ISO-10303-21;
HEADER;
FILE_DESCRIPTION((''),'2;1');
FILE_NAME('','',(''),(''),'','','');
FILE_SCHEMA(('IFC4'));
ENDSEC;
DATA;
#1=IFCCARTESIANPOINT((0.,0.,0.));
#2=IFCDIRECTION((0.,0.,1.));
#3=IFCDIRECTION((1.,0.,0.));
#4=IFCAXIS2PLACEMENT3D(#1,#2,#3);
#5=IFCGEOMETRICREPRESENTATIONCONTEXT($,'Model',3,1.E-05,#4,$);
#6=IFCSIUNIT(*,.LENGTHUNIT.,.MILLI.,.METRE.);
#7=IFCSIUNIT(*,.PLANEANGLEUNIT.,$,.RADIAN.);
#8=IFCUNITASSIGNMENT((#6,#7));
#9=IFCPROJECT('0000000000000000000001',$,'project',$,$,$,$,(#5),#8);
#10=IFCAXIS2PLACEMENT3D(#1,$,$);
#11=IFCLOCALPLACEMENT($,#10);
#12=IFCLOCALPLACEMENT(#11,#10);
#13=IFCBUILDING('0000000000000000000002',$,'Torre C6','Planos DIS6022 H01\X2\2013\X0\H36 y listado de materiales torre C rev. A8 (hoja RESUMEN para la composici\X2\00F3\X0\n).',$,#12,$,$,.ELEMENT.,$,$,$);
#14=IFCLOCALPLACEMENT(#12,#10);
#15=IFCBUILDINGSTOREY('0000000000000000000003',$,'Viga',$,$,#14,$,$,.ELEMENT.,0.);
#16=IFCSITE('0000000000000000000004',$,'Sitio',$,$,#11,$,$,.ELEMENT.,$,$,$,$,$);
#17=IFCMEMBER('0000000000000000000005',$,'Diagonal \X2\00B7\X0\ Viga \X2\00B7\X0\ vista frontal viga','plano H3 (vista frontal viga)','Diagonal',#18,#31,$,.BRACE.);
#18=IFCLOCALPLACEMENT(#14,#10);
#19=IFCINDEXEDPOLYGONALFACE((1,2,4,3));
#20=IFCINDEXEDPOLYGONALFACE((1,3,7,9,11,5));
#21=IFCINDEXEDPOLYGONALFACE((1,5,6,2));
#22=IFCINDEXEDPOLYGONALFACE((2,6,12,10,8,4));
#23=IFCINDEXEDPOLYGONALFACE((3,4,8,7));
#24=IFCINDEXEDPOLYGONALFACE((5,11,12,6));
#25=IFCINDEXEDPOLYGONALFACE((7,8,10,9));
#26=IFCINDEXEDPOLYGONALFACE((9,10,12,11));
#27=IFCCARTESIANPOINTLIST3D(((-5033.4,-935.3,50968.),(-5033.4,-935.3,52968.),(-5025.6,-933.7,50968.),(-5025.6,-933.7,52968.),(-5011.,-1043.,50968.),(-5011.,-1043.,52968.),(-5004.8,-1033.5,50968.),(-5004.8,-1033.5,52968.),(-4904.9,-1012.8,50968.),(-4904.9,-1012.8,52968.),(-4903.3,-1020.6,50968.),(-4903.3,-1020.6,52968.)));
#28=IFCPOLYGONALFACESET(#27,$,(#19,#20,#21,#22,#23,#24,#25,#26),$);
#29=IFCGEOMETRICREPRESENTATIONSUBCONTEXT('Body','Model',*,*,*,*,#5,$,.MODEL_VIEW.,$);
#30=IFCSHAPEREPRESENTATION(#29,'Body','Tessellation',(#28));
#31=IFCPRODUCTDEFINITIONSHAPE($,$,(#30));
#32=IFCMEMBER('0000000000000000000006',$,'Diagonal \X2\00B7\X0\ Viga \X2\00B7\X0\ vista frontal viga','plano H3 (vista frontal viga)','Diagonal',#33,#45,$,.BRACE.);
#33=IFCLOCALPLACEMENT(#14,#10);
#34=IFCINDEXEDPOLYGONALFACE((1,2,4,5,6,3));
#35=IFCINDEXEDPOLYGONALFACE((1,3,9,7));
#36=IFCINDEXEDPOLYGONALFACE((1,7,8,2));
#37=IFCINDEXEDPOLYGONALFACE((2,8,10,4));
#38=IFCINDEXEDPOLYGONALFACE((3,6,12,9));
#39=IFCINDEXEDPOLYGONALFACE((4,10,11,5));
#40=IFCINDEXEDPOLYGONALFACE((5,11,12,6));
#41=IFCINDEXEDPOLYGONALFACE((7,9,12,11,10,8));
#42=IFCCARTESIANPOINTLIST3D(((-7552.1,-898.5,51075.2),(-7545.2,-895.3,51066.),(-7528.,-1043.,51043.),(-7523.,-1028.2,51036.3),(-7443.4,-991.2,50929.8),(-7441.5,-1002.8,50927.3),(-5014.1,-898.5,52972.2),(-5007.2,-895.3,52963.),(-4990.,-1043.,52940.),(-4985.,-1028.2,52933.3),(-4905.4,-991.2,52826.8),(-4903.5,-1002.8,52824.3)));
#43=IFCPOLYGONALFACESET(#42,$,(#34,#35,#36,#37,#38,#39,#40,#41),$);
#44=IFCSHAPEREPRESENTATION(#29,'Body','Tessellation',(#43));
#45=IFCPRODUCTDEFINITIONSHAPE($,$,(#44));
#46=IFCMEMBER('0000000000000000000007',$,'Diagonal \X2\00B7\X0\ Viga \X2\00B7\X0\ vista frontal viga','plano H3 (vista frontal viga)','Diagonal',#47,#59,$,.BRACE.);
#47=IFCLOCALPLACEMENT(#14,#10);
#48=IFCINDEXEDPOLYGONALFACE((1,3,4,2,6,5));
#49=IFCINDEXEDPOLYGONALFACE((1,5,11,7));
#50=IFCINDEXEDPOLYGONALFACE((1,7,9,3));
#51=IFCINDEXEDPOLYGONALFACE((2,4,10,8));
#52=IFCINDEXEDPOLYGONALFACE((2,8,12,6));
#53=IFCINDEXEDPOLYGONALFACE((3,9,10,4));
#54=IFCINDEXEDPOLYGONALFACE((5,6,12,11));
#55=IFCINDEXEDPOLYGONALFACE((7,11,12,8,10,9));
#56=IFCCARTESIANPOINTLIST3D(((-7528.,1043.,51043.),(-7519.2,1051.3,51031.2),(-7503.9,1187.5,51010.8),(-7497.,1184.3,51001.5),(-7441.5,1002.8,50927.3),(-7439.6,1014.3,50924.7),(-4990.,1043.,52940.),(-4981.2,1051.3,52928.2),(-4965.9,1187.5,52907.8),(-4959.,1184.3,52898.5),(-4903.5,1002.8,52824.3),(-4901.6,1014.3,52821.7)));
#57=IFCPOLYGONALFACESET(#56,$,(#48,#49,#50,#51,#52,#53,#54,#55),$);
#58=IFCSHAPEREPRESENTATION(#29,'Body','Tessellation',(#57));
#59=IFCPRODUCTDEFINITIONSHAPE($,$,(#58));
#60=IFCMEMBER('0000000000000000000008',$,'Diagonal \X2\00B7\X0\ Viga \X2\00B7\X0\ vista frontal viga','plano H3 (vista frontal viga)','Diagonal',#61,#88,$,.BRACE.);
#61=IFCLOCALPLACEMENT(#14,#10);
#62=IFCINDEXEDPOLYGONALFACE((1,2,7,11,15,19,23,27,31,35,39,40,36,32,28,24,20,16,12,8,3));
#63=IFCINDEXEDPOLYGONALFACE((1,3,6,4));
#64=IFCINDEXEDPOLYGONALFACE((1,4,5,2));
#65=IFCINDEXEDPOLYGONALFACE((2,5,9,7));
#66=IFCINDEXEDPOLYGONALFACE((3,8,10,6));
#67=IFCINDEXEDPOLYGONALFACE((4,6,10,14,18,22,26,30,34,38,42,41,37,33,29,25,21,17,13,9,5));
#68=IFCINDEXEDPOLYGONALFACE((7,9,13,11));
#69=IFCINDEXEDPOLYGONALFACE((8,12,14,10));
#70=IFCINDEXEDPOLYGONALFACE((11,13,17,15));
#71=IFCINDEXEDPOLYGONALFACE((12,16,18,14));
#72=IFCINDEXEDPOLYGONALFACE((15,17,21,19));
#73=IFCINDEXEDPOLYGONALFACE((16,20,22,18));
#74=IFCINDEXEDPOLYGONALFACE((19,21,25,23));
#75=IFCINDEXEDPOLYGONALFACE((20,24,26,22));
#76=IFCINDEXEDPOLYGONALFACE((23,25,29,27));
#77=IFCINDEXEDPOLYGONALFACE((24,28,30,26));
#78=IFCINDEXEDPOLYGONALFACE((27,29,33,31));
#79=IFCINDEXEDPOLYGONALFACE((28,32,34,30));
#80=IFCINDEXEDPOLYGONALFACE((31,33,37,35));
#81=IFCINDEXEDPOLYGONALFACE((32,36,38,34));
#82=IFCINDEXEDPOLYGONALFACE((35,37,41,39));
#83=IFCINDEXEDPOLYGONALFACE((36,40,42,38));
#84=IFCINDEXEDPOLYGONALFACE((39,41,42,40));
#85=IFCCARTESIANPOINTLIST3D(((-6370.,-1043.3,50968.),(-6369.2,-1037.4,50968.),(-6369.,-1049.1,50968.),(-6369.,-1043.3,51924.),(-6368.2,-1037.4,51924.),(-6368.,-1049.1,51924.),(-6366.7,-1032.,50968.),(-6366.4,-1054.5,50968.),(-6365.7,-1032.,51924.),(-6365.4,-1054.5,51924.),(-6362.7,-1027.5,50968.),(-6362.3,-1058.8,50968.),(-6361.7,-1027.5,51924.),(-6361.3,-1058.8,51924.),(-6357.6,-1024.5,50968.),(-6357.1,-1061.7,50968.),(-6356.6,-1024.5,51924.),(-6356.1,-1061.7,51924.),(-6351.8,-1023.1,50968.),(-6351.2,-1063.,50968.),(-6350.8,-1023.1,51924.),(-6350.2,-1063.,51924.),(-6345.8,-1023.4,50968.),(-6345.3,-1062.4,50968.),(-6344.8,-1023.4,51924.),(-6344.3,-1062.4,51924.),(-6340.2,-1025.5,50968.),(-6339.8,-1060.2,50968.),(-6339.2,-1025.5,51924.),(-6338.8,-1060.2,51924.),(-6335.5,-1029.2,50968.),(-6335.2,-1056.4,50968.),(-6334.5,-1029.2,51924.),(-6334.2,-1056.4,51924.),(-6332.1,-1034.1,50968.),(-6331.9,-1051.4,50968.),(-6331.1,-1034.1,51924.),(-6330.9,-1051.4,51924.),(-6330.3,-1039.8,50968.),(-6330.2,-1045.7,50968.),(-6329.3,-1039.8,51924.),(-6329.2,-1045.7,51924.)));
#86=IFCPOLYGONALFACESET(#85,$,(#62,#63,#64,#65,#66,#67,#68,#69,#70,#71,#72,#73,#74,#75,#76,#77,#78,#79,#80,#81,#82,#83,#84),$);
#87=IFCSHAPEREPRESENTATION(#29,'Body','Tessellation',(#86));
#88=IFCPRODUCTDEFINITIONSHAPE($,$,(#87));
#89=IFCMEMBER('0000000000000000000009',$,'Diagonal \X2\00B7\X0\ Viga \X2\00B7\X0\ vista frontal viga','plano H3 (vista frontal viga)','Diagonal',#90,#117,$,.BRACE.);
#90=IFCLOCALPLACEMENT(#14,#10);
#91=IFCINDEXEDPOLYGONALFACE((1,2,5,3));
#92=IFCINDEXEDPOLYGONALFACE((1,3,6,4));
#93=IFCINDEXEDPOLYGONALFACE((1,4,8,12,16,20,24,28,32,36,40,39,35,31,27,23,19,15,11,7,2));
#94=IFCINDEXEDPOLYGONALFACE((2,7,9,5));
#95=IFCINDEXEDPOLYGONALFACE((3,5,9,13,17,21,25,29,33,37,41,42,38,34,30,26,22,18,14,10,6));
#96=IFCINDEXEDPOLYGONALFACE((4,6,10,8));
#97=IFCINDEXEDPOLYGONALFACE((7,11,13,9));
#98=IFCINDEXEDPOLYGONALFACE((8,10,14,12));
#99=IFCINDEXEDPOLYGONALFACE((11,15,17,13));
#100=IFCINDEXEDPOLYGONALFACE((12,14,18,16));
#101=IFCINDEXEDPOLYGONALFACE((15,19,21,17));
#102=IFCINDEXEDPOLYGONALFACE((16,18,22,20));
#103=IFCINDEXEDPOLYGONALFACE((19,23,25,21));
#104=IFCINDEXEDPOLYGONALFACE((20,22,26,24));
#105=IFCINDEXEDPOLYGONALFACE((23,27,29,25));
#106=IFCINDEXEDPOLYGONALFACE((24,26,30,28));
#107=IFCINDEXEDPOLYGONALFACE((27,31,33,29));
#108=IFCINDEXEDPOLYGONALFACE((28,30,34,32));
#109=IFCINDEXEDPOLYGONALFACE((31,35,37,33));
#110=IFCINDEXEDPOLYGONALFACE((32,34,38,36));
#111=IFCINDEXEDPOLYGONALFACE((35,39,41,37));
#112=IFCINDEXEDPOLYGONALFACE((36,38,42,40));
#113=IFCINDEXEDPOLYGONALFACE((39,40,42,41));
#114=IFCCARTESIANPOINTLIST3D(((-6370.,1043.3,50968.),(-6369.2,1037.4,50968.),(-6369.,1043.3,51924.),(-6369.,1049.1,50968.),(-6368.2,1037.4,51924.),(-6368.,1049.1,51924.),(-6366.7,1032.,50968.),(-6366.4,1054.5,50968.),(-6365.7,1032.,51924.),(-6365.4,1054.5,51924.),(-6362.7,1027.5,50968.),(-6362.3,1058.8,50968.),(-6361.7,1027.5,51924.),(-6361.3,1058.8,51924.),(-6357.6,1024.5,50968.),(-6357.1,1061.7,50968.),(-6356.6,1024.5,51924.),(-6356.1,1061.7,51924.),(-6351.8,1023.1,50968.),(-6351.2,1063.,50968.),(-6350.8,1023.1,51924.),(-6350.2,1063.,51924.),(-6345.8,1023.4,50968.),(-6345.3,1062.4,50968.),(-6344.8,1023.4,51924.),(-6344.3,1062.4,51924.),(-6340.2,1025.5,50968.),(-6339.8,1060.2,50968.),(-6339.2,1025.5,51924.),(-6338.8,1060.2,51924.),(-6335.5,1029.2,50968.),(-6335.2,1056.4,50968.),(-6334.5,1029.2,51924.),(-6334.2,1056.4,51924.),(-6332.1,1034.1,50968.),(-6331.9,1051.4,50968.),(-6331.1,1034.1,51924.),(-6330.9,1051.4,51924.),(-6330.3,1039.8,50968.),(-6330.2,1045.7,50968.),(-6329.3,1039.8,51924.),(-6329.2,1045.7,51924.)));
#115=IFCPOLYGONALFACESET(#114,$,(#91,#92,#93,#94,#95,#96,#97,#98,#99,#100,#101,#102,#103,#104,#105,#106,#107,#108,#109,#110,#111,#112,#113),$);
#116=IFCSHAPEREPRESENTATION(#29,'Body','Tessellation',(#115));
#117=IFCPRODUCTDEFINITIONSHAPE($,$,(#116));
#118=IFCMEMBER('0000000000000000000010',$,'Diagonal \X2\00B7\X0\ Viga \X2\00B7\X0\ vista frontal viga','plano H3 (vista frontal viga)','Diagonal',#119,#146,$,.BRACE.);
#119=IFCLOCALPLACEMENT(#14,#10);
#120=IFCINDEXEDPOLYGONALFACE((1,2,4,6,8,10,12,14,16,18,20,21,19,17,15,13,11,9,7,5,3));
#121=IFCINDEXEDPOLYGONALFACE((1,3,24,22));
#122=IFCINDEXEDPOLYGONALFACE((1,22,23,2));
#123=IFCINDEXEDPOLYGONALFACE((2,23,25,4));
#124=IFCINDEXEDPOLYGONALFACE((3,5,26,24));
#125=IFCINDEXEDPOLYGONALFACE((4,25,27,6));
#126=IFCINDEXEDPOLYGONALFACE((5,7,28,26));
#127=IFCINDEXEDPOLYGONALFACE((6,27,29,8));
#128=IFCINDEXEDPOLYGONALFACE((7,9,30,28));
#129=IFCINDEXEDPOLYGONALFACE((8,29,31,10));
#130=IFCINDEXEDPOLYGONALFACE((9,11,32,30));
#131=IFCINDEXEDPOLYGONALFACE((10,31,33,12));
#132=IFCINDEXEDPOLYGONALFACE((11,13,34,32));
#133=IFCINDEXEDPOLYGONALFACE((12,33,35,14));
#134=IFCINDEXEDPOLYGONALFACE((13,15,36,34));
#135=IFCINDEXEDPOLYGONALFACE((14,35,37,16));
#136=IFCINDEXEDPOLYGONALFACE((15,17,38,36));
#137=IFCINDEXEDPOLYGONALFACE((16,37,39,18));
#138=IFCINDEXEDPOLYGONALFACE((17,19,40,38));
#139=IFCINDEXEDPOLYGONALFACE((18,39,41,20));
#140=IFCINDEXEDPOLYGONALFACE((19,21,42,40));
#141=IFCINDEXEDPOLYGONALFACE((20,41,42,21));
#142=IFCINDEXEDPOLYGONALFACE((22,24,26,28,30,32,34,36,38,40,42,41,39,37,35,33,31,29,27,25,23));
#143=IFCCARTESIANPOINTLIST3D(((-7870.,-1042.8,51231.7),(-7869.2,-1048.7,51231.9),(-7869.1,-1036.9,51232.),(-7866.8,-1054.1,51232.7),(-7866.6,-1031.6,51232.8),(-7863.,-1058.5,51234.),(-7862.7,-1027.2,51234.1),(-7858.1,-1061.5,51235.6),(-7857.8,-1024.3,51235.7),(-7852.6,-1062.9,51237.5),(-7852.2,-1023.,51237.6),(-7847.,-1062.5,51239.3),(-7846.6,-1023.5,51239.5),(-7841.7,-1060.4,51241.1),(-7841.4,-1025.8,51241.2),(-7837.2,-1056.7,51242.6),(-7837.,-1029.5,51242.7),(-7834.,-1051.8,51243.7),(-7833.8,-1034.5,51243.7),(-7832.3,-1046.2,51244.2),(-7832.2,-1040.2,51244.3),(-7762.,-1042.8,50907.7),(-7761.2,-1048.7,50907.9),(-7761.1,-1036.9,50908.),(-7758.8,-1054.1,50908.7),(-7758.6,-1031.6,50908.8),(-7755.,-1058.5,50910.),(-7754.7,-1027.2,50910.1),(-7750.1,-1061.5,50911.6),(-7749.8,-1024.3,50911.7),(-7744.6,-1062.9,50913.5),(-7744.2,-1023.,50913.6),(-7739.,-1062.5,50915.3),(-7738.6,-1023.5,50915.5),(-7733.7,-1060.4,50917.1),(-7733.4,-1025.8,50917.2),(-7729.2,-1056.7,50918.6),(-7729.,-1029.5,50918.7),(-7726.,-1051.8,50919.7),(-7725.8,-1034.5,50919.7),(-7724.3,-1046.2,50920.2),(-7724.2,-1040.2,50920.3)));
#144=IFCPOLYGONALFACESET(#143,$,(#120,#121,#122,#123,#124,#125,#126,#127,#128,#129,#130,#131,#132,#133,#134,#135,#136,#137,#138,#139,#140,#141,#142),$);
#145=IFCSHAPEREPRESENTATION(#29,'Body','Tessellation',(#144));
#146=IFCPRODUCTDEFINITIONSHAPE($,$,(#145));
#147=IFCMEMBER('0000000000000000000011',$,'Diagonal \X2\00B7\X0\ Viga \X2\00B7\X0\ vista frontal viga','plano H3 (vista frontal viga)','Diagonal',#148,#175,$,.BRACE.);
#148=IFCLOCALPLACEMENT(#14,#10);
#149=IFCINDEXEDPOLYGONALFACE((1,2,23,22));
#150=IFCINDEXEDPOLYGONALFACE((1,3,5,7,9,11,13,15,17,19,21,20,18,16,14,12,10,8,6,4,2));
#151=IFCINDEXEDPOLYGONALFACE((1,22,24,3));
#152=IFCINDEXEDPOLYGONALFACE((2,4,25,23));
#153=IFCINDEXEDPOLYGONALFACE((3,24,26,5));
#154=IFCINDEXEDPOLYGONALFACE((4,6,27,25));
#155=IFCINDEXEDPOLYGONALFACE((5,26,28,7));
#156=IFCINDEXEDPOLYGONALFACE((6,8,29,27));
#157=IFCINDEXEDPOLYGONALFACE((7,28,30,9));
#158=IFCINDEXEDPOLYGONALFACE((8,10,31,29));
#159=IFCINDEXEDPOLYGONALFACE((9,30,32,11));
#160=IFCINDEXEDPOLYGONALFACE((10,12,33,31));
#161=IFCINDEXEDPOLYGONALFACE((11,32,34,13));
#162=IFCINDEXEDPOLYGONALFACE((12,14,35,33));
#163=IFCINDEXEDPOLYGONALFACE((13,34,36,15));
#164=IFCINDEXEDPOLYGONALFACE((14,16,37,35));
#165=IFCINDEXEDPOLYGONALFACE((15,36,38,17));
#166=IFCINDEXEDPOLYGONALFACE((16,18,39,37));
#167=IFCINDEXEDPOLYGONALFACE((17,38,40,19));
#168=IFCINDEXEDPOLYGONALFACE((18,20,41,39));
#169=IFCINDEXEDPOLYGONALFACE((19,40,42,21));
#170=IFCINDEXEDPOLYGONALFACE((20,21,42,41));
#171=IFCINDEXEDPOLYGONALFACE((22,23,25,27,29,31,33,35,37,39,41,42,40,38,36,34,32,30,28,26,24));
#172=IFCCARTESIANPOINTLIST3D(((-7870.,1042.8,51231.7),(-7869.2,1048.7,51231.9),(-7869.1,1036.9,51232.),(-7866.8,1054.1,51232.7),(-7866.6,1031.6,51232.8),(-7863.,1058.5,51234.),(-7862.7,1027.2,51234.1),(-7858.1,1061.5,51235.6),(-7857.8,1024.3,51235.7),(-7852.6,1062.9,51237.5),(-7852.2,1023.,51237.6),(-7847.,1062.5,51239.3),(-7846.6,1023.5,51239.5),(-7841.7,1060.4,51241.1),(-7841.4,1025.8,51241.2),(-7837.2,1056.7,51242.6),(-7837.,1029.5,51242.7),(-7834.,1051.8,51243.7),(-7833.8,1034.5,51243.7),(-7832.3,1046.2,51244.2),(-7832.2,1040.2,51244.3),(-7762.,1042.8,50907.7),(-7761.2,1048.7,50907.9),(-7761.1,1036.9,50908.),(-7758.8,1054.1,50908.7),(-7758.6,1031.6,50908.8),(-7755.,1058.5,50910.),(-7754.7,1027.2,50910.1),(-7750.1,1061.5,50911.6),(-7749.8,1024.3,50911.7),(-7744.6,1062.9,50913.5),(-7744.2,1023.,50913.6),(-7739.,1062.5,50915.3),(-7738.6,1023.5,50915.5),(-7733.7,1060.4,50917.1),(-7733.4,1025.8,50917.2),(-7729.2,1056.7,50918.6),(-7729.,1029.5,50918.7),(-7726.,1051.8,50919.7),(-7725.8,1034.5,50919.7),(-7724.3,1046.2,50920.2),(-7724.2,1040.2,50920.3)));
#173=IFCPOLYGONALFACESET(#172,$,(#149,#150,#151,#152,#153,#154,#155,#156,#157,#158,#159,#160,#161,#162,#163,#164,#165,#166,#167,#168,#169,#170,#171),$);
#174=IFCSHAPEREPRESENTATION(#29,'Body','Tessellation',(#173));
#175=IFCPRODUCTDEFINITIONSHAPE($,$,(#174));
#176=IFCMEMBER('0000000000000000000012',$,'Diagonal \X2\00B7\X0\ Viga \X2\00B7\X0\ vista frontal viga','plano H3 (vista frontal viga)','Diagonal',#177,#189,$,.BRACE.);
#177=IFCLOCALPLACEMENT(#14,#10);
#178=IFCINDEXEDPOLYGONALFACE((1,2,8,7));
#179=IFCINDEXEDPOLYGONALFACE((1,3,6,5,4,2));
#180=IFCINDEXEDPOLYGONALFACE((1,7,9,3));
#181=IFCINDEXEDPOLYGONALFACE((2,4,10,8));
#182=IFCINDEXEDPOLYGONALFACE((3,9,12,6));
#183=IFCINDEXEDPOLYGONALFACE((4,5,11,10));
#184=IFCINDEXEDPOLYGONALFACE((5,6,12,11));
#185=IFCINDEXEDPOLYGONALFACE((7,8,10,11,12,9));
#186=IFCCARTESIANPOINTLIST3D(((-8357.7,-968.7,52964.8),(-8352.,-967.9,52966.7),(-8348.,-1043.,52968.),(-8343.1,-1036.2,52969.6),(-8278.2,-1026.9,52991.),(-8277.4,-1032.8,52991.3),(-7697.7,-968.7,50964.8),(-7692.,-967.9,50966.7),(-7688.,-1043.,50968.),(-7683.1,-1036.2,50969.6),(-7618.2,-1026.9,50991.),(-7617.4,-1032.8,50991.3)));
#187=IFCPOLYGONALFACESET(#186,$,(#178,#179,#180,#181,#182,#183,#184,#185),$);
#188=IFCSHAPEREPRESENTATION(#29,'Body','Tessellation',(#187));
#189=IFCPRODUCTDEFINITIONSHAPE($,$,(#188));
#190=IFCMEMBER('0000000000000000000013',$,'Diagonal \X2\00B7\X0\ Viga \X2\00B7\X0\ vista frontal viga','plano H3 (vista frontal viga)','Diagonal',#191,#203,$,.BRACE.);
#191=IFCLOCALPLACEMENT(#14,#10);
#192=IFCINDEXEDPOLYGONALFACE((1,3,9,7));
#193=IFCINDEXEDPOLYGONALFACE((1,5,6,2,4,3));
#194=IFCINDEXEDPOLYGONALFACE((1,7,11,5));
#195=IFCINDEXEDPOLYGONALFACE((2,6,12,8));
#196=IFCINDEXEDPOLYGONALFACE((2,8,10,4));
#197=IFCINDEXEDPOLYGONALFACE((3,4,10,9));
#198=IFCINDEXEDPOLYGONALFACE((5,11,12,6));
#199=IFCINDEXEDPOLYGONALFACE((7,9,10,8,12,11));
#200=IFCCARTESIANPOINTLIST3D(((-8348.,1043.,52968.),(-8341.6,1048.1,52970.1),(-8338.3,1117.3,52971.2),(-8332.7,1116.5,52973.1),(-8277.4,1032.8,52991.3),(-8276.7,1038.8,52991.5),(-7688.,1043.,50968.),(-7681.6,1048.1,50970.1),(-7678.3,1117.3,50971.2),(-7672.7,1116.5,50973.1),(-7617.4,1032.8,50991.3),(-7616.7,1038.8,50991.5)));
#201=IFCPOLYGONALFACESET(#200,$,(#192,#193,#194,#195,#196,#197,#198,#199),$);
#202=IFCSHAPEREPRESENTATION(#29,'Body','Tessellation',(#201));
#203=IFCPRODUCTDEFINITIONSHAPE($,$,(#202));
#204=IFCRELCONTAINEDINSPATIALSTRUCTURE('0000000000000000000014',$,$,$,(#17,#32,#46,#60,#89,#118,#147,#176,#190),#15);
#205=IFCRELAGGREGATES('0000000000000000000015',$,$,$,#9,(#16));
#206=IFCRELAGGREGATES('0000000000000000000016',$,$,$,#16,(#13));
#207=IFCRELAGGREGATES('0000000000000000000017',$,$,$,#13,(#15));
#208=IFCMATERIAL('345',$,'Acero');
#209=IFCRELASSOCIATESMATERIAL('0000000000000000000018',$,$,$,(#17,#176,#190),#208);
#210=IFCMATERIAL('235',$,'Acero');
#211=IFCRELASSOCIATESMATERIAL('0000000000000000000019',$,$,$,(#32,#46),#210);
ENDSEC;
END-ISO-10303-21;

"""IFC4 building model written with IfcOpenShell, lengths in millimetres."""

from ifc_helpers import new_model, si_unit, frame, frame_2d, origin, origin_with_axes, place, context, subcontext, project, spatial, circle, l_section, extrude, material, element, save


model = new_model("IFC4")

# Units and contexts
model_context = context("Model", 3, precision=1e-05, world=origin_with_axes())
body_context = subcontext(model_context, "Body", "Model", "MODEL_VIEW")
ifc_project = project(units=[si_unit("LENGTHUNIT", "METRE", prefix="MILLI"), si_unit("PLANEANGLEUNIT", "RADIAN")], contexts=[model_context])

# Site, building, storey
site_placement = place(None, origin())
site = spatial("IfcSite", under=ifc_project, at=site_placement, Name="Sitio", CompositionType="ELEMENT")
building_placement = place(site_placement, origin())
building = spatial("IfcBuilding", under=site, at=building_placement, Name="Torre C6", Description="Planos DIS6022 H01–H36 y listado de materiales torre C rev. A8 (hoja RESUMEN para la composición).", CompositionType="ELEMENT")
storey_placement = place(building_placement, origin())
storey = spatial("IfcBuildingStorey", under=building, at=storey_placement, Name="Viga", CompositionType="ELEMENT", Elevation=0.0)

# Members
ifc_material_1 = material(Name="345", Category="Acero")
member_1_placement = place(storey_placement, frame((-5011.0, -1043.0, 50968.0), z_axis=(0.0, 0.0, 1.0), x_axis=(0.979018, 0.203775, 0.0)))
element("IfcMember", 1, at=member_1_placement, inside=storey, material=ifc_material_1, Name="Diagonal · Viga · vista frontal viga", Description="plano H3 (vista frontal viga)", ObjectType="Diagonal", PredefinedType="BRACE", context=body_context, shape_type="SweptSolid", body=[
    extrude(l_section(Depth=110.0, Width=110.0, Thickness=8.0, at=frame_2d((55.0, 55.0))), None, (0.0, 0.0, 1.0), 2000.0),
])
ifc_material_2 = material(Name="235", Category="Acero")
for number, where, z_axis, x_axis, name in (
    (2, (-7528.0, -1043.0, 51043.0), (0.800984, 0.0, 0.598686), (0.576761, 0.268149, -0.771649), "Diagonal · Viga · vista frontal viga"),
    (3, (-7528.0, 1043.0, 51043.0), (0.800984, 0.0, 0.598686), (0.576761, -0.268149, -0.771649), "Diagonal · Viga · vista frontal viga"),
):
    element("IfcMember", number, at=place(storey_placement, frame(where, z_axis=z_axis, x_axis=x_axis)), inside=storey, material=ifc_material_2, Name=name, Description="plano H3 (vista frontal viga)", ObjectType="Diagonal", PredefinedType="BRACE", context=body_context, shape_type="SweptSolid", body=[
        extrude(l_section(Depth=150.0, Width=150.0, Thickness=12.0, at=frame_2d((75.0, 75.0))), None, (0.0, 0.0, 1.0), 3168.6),
    ])
for number, where, z_axis, x_axis, name in (
    (4, (-6349.0, -1043.0, 51924.0), (-0.001046, 0.0, -0.999999), (0.986775, 0.162093, -0.001032), "Diagonal · Viga · vista frontal viga"),
    (5, (-6349.0, 1043.0, 51924.0), (-0.001046, 0.0, -0.999999), (0.986775, -0.162093, -0.001032), "Diagonal · Viga · vista frontal viga"),
):
    element("IfcMember", number, at=place(storey_placement, frame(where, z_axis=z_axis, x_axis=x_axis)), inside=storey, Name=name, Description="plano H3 (vista frontal viga)", ObjectType="Diagonal", PredefinedType="BRACE", context=body_context, shape_type="SweptSolid", body=[
        extrude(circle(Radius=20.0), None, (0.0, 0.0, 1.0), 956.0),
    ])
for number, where, z_axis, x_axis, name in (
    (6, (-7743.0, -1043.0, 50914.0), (-0.316228, 0.0, 0.948683), (0.939391, 0.139624, 0.31313), "Diagonal · Viga · vista frontal viga"),
    (7, (-7743.0, 1043.0, 50914.0), (-0.316228, 0.0, 0.948683), (0.939391, -0.139624, 0.31313), "Diagonal · Viga · vista frontal viga"),
):
    element("IfcMember", number, at=place(storey_placement, frame(where, z_axis=z_axis, x_axis=x_axis)), inside=storey, Name=name, Description="plano H3 (vista frontal viga)", ObjectType="Diagonal", PredefinedType="BRACE", context=body_context, shape_type="SweptSolid", body=[
        extrude(circle(Radius=20.0), None, (0.0, 0.0, 1.0), 341.5),
    ])
for number, where, z_axis, x_axis, name in (
    (8, (-7688.0, -1043.0, 50968.0), (-0.313377, 0.0, 0.949629), (0.940843, 0.135715, 0.310478), "Diagonal · Viga · vista frontal viga"),
    (9, (-7688.0, 1043.0, 50968.0), (-0.313377, 0.0, 0.949629), (0.940843, -0.135715, 0.310478), "Diagonal · Viga · vista frontal viga"),
):
    element("IfcMember", number, at=place(storey_placement, frame(where, z_axis=z_axis, x_axis=x_axis)), inside=storey, material=ifc_material_1, Name=name, Description="plano H3 (vista frontal viga)", ObjectType="Diagonal", PredefinedType="BRACE", context=body_context, shape_type="SweptSolid", body=[
        extrude(l_section(Depth=75.0, Width=75.0, Thickness=6.0, at=frame_2d((37.5, 37.5))), None, (0.0, 0.0, 1.0), 2106.1),
    ])

save(model, "model.ifc")
